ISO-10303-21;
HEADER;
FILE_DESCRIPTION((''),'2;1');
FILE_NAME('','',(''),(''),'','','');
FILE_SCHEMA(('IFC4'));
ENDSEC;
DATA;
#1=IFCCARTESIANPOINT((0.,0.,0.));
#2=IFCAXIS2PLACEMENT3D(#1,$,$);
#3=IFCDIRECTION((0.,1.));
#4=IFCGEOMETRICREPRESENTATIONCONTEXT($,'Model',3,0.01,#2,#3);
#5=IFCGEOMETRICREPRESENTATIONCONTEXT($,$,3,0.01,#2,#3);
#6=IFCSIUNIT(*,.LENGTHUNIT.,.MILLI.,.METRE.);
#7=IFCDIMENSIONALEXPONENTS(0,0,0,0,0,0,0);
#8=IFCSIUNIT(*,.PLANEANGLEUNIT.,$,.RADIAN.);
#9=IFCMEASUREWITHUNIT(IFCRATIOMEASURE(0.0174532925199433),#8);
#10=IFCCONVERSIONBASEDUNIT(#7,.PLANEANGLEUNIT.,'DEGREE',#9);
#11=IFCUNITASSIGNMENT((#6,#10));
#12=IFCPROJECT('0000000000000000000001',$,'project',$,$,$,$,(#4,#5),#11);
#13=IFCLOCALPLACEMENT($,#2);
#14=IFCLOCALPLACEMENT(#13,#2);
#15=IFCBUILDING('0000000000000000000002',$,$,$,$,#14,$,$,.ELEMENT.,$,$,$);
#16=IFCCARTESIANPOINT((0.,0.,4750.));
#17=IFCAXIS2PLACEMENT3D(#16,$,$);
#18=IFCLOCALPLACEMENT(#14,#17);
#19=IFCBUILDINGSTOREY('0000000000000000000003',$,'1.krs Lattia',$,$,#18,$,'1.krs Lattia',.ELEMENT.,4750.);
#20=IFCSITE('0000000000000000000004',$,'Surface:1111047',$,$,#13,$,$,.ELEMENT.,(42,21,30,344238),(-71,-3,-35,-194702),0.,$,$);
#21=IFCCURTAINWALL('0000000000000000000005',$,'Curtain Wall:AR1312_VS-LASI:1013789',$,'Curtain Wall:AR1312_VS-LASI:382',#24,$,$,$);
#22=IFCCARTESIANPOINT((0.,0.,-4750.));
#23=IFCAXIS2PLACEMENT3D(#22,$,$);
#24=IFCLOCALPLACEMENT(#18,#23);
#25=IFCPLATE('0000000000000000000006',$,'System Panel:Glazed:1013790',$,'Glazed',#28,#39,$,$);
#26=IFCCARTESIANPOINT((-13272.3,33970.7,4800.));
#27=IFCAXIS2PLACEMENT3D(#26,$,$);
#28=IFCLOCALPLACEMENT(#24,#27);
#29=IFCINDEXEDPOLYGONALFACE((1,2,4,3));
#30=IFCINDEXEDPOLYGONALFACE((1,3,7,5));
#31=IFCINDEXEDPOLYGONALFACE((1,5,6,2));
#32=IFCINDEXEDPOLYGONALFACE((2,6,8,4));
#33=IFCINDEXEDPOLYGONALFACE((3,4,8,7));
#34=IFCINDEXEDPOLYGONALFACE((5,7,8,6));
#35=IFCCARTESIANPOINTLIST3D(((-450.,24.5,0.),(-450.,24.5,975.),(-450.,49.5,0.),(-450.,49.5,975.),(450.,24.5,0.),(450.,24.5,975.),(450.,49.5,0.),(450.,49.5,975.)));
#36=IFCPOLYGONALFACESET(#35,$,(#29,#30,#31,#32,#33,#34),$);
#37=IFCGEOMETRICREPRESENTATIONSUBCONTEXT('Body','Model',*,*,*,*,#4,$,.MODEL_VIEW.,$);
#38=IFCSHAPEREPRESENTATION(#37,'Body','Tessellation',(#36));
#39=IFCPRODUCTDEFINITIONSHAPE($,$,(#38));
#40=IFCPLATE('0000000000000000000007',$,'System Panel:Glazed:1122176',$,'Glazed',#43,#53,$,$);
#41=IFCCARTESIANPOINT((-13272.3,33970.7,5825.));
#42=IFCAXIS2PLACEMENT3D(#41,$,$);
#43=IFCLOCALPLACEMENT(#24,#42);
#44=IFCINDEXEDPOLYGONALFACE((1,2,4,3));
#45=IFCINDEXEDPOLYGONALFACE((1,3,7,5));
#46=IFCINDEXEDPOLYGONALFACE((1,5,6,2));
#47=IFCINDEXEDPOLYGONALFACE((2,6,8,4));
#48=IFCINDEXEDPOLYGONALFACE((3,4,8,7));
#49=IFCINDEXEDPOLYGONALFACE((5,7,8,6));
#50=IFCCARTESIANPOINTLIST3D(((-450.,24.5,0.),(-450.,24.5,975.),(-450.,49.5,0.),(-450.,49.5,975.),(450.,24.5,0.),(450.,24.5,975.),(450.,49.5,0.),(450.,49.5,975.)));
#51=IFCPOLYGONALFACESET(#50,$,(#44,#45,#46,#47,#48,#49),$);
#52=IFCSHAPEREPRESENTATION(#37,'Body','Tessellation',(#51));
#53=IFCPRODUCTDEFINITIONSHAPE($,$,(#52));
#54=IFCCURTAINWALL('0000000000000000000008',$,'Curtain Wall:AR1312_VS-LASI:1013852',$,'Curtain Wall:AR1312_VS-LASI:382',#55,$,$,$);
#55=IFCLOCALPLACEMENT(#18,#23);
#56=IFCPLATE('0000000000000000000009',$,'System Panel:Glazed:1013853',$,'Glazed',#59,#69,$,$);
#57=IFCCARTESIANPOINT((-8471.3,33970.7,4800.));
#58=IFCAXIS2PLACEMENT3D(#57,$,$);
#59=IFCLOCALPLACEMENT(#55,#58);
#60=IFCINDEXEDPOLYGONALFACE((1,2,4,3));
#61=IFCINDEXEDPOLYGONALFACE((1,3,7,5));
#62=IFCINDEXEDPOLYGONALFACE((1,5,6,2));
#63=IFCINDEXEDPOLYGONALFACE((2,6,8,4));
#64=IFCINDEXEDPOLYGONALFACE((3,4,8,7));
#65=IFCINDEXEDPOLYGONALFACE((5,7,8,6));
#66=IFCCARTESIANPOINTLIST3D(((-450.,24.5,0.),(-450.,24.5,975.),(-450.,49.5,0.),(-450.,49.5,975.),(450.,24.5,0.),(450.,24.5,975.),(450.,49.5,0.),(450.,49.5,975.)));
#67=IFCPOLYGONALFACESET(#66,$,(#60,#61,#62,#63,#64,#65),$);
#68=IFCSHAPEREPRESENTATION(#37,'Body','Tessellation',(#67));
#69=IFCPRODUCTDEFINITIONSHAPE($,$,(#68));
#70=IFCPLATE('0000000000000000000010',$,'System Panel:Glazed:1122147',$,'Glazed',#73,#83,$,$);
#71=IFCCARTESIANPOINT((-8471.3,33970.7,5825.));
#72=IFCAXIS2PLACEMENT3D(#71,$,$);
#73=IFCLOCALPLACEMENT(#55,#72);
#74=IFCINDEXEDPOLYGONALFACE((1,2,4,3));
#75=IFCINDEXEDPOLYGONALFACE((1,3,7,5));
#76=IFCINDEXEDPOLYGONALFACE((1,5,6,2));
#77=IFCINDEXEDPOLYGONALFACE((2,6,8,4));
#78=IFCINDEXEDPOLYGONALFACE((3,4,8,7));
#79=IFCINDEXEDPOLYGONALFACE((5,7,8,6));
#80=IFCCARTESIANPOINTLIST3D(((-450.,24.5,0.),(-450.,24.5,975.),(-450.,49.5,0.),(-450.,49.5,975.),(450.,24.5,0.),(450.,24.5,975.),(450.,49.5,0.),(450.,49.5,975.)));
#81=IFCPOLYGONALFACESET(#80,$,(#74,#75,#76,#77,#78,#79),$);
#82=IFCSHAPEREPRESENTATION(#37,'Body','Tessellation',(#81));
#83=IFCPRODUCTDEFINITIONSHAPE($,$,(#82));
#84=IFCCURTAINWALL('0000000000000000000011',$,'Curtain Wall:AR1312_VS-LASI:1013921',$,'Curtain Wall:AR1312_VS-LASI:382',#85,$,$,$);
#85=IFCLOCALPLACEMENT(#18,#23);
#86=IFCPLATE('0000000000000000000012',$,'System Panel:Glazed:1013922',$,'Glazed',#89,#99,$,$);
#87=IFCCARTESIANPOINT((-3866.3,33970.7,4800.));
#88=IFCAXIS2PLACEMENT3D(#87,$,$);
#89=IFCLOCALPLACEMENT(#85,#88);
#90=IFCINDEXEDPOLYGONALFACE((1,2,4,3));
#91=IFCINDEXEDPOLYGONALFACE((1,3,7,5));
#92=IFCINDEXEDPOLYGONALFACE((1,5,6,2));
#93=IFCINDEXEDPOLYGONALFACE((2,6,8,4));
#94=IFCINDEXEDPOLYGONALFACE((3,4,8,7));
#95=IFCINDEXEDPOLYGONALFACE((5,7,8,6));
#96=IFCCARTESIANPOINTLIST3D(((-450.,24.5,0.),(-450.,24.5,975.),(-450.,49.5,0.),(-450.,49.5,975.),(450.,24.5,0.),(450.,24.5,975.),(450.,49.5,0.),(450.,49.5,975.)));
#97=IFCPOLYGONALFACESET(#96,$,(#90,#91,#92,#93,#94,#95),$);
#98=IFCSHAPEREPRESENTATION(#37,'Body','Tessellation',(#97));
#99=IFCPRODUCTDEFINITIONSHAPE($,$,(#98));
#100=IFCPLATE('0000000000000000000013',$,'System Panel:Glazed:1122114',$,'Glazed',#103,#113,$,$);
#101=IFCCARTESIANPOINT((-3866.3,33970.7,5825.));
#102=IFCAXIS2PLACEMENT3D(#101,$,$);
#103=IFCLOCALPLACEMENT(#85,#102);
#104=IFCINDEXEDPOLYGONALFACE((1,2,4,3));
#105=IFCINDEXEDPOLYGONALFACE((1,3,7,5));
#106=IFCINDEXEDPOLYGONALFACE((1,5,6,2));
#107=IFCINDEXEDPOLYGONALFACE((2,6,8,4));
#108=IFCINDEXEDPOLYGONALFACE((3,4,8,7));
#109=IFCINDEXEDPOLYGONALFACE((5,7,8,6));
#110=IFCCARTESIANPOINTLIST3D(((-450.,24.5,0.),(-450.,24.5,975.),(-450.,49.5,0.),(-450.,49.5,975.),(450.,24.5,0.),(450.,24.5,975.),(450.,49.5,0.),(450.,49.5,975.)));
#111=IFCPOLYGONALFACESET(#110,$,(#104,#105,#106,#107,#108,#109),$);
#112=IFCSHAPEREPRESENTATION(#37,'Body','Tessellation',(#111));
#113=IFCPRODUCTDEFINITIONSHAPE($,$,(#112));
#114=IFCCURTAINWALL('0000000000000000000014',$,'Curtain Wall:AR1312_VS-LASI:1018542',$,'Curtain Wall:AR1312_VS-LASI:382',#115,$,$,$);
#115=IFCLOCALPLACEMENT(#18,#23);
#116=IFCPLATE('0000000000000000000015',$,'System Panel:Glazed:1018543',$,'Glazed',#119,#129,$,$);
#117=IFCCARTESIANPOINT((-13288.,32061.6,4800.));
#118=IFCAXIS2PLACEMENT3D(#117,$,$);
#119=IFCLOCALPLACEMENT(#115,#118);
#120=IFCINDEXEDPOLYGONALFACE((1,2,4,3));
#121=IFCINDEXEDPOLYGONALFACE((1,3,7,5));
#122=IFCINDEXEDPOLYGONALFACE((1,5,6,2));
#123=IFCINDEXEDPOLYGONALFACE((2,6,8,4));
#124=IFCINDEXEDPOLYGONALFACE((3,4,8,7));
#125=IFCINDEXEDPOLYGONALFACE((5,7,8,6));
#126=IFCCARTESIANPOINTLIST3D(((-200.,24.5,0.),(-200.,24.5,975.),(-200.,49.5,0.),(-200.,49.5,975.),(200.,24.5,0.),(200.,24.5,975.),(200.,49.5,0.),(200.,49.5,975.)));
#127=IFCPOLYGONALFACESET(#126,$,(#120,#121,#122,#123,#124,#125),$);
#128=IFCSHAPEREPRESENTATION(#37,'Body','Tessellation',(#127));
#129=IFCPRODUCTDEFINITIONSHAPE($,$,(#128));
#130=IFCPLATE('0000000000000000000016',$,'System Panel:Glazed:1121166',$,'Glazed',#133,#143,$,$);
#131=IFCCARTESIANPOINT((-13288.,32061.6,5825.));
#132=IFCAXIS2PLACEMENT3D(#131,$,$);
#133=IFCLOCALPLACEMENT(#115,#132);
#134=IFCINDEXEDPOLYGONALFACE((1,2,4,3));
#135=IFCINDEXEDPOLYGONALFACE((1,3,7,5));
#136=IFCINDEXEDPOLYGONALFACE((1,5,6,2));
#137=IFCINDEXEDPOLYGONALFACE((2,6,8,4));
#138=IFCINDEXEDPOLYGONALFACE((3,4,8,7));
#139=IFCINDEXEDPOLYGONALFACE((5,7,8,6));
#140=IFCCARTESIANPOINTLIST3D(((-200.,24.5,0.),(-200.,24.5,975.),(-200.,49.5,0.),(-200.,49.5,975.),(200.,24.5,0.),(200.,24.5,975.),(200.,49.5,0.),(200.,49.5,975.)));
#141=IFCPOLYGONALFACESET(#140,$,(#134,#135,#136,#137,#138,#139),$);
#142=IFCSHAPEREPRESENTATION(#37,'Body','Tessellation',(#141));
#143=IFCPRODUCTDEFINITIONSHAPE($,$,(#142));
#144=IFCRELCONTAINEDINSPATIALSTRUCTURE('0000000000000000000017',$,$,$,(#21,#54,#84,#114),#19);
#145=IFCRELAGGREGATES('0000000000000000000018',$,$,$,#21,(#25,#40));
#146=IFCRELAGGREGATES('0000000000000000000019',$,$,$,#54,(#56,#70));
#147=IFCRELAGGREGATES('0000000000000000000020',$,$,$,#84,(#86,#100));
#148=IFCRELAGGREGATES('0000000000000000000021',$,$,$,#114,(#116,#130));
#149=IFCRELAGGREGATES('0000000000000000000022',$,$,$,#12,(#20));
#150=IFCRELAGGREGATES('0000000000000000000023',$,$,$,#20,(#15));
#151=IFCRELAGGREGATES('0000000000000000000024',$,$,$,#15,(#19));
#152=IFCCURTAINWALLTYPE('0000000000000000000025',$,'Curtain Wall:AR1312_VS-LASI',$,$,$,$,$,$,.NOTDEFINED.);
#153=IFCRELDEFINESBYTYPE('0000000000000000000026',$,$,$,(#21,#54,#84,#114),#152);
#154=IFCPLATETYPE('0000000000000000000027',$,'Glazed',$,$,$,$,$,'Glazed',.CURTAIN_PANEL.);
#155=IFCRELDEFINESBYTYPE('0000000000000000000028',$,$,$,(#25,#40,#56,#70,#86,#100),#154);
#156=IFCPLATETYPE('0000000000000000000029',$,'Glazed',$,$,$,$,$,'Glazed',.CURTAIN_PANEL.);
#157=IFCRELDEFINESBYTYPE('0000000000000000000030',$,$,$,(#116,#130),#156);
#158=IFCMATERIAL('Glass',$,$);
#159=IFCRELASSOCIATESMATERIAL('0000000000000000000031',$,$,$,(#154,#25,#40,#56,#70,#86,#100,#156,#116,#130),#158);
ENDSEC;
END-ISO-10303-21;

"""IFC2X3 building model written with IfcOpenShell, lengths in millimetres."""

from ifc_helpers import new_model, entity, si_unit, converted_unit, direction, frame, origin, origin_2d_with_axis, place, context, subcontext, project, spatial, rectangle, extrude, source, transform, mapped, material, type_object, type_shapes, element, aggregate, save


model = new_model("IFC2X3")

# Units and contexts
model_context = context("Model", 3, precision=0.01, world=origin(), true_north=direction((0.0, 1.0)))
context_of_model = context(None, 3, precision=0.01, world=origin(), true_north=direction((0.0, 1.0)))
body_context = subcontext(model_context, "Body", "Model", "MODEL_VIEW")
ifc_project = project(units=[si_unit("LENGTHUNIT", "METRE", prefix="MILLI"), converted_unit("PLANEANGLEUNIT", "DEGREE", entity("IfcRatioMeasure", 0.0174532925199433), si_unit("PLANEANGLEUNIT", "RADIAN"), dimensions=[0, 0, 0, 0, 0, 0, 0])], contexts=[model_context, context_of_model])

# Site, building, storey
site_placement = place(None, origin())
site = spatial("IfcSite", under=ifc_project, at=site_placement, Name="Surface:1111047", CompositionType="ELEMENT", RefLatitude=(42, 21, 30, 344238), RefLongitude=(-71, -3, -35, -194702), RefElevation=0.0)
building_placement = place(site_placement, origin())
building = spatial("IfcBuilding", under=site, at=building_placement, CompositionType="ELEMENT")
storey_placement = place(building_placement, frame((0.0, 0.0, 4750.0)))
storey = spatial("IfcBuildingStorey", under=building, at=storey_placement, Name="1.krs Lattia", LongName="1.krs Lattia", CompositionType="ELEMENT", Elevation=4750.0)

# Curtain walls, plates
curtain_wall_type = type_object("IfcCurtainWallType", Name="Curtain Wall:AR1312_VS-LASI", PredefinedType="NOTDEFINED")
curtain_wall_1_placement = place(storey_placement, frame((0.0, 0.0, -4750.0)))
curtain_wall_1 = element("IfcCurtainWall", 1, at=curtain_wall_1_placement, inside=storey, type_object=curtain_wall_type, Name="Curtain Wall:AR1312_VS-LASI:1013789", ObjectType="Curtain Wall:AR1312_VS-LASI:382")
ifc_material_1 = material(Name="Glass")
plate_type_1 = type_object("IfcPlateType", Name="Glazed", ElementType="Glazed", PredefinedType="CURTAIN_PANEL", material=ifc_material_1)
shared_shape_1 = source(origin(), body_context, "Body", "SweptSolid", [
    extrude(rectangle(XDim=25.0, YDim=900.0, at=origin_2d_with_axis()), frame((0.0, 37.0, 0.0), z_axis=(0.0, 0.0, 1.0), x_axis=(0.0, 1.0, 0.0)), (0.0, 0.0, 1.0), 975.0),
])
type_shapes(plate_type_1, [shared_shape_1])
plate_1_placement = place(curtain_wall_1_placement, frame((-13272.3, 33970.7, 4800.0)))
plate_1 = element("IfcPlate", 2, at=plate_1_placement, type_object=plate_type_1, material=ifc_material_1, Name="System Panel:Glazed:1013790", ObjectType="Glazed", context=body_context, shape_type="MappedRepresentation", body=[
    mapped(shared_shape_1, transform((0.0, 0.0, 0.0), scale=1.0)),
])
plate_2_placement = place(curtain_wall_1_placement, frame((-13272.3, 33970.7, 5825.0)))
plate_2 = element("IfcPlate", 3, at=plate_2_placement, type_object=plate_type_1, material=ifc_material_1, Name="System Panel:Glazed:1122176", ObjectType="Glazed", context=body_context, shape_type="MappedRepresentation", body=[
    mapped(shared_shape_1, transform((0.0, 0.0, 0.0), scale=1.0)),
])
aggregate(curtain_wall_1, [plate_1, plate_2])
curtain_wall_2_placement = place(storey_placement, frame((0.0, 0.0, -4750.0)))
curtain_wall_2 = element("IfcCurtainWall", 4, at=curtain_wall_2_placement, inside=storey, type_object=curtain_wall_type, Name="Curtain Wall:AR1312_VS-LASI:1013852", ObjectType="Curtain Wall:AR1312_VS-LASI:382")
plate_3_placement = place(curtain_wall_2_placement, frame((-8471.3, 33970.7, 4800.0)))
plate_3 = element("IfcPlate", 5, at=plate_3_placement, type_object=plate_type_1, material=ifc_material_1, Name="System Panel:Glazed:1013853", ObjectType="Glazed", context=body_context, shape_type="MappedRepresentation", body=[
    mapped(shared_shape_1, transform((0.0, 0.0, 0.0), scale=1.0)),
])
plate_4_placement = place(curtain_wall_2_placement, frame((-8471.3, 33970.7, 5825.0)))
plate_4 = element("IfcPlate", 6, at=plate_4_placement, type_object=plate_type_1, material=ifc_material_1, Name="System Panel:Glazed:1122147", ObjectType="Glazed", context=body_context, shape_type="MappedRepresentation", body=[
    mapped(shared_shape_1, transform((0.0, 0.0, 0.0), scale=1.0)),
])
aggregate(curtain_wall_2, [plate_3, plate_4])
curtain_wall_3_placement = place(storey_placement, frame((0.0, 0.0, -4750.0)))
curtain_wall_3 = element("IfcCurtainWall", 7, at=curtain_wall_3_placement, inside=storey, type_object=curtain_wall_type, Name="Curtain Wall:AR1312_VS-LASI:1013921", ObjectType="Curtain Wall:AR1312_VS-LASI:382")
plate_5_placement = place(curtain_wall_3_placement, frame((-3866.3, 33970.7, 4800.0)))
plate_5 = element("IfcPlate", 8, at=plate_5_placement, type_object=plate_type_1, material=ifc_material_1, Name="System Panel:Glazed:1013922", ObjectType="Glazed", context=body_context, shape_type="MappedRepresentation", body=[
    mapped(shared_shape_1, transform((0.0, 0.0, 0.0), scale=1.0)),
])
plate_6_placement = place(curtain_wall_3_placement, frame((-3866.3, 33970.7, 5825.0)))
plate_6 = element("IfcPlate", 9, at=plate_6_placement, type_object=plate_type_1, material=ifc_material_1, Name="System Panel:Glazed:1122114", ObjectType="Glazed", context=body_context, shape_type="MappedRepresentation", body=[
    mapped(shared_shape_1, transform((0.0, 0.0, 0.0), scale=1.0)),
])
aggregate(curtain_wall_3, [plate_5, plate_6])
curtain_wall_4_placement = place(storey_placement, frame((0.0, 0.0, -4750.0)))
curtain_wall_4 = element("IfcCurtainWall", 10, at=curtain_wall_4_placement, inside=storey, type_object=curtain_wall_type, Name="Curtain Wall:AR1312_VS-LASI:1018542", ObjectType="Curtain Wall:AR1312_VS-LASI:382")
plate_type_2 = type_object("IfcPlateType", Name="Glazed", ElementType="Glazed", PredefinedType="CURTAIN_PANEL", material=ifc_material_1)
shared_shape_2 = source(origin(), body_context, "Body", "SweptSolid", [
    extrude(rectangle(XDim=25.0, YDim=400.0, at=origin_2d_with_axis()), frame((0.0, 37.0, 0.0), z_axis=(0.0, 0.0, 1.0), x_axis=(0.0, 1.0, 0.0)), (0.0, 0.0, 1.0), 975.0),
])
type_shapes(plate_type_2, [shared_shape_2])
plate_7_placement = place(curtain_wall_4_placement, frame((-13288.0, 32061.6, 4800.0)))
plate_7 = element("IfcPlate", 11, at=plate_7_placement, type_object=plate_type_2, material=ifc_material_1, Name="System Panel:Glazed:1018543", ObjectType="Glazed", context=body_context, shape_type="MappedRepresentation", body=[
    mapped(shared_shape_2, transform((0.0, 0.0, 0.0), scale=1.0)),
])
plate_8_placement = place(curtain_wall_4_placement, frame((-13288.0, 32061.6, 5825.0)))
plate_8 = element("IfcPlate", 12, at=plate_8_placement, type_object=plate_type_2, material=ifc_material_1, Name="System Panel:Glazed:1121166", ObjectType="Glazed", context=body_context, shape_type="MappedRepresentation", body=[
    mapped(shared_shape_2, transform((0.0, 0.0, 0.0), scale=1.0)),
])
aggregate(curtain_wall_4, [plate_7, plate_8])

save(model, "model.ifc")
